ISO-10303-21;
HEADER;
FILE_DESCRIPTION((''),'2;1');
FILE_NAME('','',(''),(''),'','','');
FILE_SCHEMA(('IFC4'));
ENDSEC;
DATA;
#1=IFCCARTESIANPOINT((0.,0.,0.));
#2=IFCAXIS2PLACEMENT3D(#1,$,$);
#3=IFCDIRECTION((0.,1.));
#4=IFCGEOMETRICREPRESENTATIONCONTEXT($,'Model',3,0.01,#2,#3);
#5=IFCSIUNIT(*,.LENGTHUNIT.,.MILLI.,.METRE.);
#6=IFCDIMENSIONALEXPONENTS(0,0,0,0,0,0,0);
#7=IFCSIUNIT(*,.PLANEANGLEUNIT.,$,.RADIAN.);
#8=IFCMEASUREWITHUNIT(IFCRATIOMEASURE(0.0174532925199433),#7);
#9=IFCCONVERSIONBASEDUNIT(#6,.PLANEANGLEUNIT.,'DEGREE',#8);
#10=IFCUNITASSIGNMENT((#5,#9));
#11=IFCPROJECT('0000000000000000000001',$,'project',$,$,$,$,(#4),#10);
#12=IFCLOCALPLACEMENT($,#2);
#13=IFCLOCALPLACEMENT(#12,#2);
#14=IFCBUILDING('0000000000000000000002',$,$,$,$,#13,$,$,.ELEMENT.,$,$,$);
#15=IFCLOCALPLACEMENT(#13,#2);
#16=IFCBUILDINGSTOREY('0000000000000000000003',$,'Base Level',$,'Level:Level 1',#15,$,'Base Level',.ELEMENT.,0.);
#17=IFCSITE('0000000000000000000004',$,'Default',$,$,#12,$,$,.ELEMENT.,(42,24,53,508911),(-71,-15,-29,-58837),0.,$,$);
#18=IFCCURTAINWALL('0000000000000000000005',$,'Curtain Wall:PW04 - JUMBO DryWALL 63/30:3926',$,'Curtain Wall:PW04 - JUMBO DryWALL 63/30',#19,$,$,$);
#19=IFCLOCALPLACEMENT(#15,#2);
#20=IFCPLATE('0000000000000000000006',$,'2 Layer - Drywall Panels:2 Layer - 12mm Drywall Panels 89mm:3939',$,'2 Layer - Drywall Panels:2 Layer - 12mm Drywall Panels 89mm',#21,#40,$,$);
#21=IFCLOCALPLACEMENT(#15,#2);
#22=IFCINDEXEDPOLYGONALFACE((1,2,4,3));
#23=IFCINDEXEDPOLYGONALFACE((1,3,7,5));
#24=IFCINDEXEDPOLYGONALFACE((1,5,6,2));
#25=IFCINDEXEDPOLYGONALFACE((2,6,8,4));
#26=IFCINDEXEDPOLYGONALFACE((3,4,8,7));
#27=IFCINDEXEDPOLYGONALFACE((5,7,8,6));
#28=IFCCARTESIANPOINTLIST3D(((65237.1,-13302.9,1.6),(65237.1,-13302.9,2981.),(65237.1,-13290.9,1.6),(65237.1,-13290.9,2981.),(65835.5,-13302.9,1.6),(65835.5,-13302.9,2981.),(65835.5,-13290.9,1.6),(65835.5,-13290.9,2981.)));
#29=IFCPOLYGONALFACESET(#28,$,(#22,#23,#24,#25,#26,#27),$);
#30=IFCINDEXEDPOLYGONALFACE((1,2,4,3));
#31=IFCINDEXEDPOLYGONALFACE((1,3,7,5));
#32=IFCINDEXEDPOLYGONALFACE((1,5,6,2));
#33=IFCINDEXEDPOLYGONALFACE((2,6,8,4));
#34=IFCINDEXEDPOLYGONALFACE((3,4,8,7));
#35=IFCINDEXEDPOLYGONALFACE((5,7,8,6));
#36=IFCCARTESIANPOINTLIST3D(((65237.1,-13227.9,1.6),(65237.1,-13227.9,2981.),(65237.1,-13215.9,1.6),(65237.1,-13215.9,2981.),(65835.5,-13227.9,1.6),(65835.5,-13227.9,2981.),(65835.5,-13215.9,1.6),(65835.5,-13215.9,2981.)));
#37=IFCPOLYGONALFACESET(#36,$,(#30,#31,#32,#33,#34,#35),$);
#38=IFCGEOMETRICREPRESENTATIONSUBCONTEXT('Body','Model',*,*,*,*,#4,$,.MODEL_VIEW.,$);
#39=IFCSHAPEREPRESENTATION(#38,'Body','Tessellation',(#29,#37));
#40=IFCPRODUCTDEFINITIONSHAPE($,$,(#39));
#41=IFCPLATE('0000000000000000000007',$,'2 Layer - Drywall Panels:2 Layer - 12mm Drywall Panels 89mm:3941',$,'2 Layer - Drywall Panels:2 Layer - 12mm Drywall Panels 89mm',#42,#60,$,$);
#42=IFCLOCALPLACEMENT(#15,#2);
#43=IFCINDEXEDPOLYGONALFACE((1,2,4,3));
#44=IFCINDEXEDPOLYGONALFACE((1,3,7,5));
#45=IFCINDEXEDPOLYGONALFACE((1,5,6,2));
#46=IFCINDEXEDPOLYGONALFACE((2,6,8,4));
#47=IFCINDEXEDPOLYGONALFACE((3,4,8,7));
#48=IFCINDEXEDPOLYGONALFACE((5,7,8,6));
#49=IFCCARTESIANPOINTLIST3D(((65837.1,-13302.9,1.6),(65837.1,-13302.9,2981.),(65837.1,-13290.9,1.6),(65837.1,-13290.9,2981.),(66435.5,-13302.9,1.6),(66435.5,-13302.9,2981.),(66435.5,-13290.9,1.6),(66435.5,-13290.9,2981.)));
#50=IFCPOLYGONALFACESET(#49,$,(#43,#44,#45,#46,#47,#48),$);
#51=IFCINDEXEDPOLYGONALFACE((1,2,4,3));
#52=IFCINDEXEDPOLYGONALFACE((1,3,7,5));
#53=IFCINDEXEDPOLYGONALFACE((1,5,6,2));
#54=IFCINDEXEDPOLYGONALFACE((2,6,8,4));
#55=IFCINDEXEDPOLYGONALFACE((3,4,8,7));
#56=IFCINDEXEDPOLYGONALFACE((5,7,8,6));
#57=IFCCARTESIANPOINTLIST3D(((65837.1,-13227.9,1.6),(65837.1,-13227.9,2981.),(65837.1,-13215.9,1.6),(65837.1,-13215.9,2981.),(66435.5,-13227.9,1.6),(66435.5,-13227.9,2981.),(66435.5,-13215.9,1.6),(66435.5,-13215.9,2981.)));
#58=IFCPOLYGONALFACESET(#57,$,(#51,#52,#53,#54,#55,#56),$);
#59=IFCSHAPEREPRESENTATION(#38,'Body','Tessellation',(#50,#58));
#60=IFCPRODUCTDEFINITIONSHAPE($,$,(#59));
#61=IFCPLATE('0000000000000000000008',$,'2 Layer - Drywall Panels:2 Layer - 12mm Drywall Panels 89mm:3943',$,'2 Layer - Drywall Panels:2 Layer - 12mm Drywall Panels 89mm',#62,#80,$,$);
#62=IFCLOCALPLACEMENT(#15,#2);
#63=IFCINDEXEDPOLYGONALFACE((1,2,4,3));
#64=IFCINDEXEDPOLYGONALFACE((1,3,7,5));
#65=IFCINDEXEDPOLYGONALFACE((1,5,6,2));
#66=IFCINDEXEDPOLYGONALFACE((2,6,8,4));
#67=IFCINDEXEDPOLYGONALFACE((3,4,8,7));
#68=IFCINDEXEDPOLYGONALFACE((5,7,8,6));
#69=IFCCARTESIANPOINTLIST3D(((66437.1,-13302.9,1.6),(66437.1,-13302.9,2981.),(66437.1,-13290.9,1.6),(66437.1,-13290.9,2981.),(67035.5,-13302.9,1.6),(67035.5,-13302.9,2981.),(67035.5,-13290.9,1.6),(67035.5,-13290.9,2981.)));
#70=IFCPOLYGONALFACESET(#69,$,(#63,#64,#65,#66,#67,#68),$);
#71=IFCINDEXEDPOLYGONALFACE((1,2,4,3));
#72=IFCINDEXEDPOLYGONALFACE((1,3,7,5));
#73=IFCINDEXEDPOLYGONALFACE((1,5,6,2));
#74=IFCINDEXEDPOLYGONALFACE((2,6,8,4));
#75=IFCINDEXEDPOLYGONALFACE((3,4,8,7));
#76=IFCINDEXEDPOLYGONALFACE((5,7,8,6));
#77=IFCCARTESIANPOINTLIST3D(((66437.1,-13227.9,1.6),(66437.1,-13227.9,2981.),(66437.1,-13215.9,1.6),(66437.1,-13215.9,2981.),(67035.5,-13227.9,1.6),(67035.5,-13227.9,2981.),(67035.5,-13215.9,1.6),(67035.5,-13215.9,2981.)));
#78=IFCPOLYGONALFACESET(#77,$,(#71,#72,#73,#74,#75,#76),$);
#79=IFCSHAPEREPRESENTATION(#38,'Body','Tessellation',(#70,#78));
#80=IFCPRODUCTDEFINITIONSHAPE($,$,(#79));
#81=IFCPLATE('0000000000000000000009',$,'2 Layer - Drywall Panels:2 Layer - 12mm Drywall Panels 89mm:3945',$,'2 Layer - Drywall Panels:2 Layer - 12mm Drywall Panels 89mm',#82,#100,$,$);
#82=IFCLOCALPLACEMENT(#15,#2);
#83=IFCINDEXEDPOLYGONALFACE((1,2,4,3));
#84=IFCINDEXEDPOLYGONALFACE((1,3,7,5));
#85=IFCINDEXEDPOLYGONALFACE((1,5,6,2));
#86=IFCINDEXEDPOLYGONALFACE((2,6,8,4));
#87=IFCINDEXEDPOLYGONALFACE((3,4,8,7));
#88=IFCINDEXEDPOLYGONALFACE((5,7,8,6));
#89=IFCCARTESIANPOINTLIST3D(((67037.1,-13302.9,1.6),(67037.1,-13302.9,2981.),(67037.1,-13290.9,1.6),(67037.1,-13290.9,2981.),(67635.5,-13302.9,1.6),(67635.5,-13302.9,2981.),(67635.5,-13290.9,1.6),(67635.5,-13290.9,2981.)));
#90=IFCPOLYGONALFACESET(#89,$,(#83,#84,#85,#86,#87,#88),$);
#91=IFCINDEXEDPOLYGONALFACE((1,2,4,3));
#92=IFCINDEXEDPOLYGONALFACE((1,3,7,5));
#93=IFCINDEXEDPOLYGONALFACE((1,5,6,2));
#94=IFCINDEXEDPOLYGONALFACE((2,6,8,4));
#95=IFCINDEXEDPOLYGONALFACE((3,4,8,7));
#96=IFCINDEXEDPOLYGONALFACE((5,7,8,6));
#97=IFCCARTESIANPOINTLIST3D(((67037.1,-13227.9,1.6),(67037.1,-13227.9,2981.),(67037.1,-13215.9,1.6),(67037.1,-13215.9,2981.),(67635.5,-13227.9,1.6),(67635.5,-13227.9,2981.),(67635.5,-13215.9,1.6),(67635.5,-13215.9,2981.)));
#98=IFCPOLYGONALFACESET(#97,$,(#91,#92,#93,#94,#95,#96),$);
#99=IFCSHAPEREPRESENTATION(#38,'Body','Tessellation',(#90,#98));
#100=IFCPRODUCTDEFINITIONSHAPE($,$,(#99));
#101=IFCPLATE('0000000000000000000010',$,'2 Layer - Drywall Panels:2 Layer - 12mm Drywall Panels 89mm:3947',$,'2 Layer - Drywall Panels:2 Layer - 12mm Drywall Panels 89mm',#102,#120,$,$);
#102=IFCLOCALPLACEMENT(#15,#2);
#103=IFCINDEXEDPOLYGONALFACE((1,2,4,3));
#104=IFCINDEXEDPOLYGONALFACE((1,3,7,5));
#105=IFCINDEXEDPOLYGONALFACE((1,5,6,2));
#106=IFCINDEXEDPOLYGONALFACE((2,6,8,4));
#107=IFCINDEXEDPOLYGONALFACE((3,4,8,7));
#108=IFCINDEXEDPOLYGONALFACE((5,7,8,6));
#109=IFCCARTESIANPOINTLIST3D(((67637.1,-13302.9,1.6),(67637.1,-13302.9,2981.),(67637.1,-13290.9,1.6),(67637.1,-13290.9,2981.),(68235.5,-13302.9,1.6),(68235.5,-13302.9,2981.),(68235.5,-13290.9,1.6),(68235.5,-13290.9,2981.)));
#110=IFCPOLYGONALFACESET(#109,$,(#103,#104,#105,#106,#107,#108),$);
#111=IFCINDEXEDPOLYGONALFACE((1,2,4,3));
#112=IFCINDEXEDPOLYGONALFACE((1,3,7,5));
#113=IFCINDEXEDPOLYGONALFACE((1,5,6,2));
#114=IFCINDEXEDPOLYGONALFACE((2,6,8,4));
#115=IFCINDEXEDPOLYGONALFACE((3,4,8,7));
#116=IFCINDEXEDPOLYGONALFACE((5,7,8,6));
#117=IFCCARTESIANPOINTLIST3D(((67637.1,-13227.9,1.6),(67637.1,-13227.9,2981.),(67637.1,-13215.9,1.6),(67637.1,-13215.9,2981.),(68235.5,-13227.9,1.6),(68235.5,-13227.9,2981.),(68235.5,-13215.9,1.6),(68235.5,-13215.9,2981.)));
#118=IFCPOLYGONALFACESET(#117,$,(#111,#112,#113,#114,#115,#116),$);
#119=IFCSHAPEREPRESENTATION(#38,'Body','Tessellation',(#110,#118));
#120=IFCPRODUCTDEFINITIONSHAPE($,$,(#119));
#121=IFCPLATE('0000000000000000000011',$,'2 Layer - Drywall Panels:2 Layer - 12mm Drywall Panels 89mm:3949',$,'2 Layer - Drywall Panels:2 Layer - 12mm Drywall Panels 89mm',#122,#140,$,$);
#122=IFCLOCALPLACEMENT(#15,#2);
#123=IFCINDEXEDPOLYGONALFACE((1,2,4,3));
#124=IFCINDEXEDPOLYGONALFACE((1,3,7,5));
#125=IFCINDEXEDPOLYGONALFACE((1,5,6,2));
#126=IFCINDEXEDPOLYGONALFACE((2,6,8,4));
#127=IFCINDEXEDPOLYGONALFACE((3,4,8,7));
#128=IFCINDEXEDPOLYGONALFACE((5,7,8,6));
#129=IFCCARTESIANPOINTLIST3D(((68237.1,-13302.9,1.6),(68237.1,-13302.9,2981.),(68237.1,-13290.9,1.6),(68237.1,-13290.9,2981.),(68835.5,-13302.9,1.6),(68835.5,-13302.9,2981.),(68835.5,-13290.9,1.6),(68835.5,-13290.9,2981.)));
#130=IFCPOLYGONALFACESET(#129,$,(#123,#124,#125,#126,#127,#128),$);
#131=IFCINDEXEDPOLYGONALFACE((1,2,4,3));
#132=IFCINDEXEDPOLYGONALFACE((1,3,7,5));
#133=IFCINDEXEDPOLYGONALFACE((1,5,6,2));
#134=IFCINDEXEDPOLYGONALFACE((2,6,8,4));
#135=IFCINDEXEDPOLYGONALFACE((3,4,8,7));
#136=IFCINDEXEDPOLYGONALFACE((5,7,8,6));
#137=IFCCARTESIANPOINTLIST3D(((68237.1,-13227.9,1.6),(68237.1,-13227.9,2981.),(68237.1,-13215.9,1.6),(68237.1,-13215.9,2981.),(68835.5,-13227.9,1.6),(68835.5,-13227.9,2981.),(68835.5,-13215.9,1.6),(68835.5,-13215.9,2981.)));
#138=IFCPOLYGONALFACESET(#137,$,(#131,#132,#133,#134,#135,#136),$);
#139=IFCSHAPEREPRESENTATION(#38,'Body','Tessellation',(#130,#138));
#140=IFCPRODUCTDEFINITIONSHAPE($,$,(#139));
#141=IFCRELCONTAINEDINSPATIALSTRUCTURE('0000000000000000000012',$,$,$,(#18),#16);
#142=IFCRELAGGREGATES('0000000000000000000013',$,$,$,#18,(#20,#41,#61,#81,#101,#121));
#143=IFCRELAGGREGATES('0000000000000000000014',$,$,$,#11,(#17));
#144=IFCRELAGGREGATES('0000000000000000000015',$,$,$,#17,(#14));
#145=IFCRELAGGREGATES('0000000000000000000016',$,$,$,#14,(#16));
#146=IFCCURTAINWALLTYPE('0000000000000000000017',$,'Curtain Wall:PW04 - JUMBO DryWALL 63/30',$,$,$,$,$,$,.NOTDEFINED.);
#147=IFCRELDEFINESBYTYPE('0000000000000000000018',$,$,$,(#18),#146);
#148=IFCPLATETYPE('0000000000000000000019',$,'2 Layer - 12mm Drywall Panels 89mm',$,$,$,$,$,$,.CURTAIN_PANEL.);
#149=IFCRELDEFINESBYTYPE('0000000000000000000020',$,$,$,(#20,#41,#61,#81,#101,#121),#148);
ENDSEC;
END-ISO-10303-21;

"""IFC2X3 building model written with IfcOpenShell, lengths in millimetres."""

from ifc_helpers import new_model, entity, si_unit, converted_unit, direction, frame, frame_2d, origin, place, context, subcontext, project, spatial, rectangle, extrude, source, transform, mapped, type_object, type_shapes, element, aggregate, save


model = new_model("IFC2X3")

# Units and contexts
model_context = context("Model", 3, precision=0.01, world=origin(), true_north=direction((0.0, 1.0)))
body_context = subcontext(model_context, "Body", "Model", "MODEL_VIEW")
ifc_project = project(units=[si_unit("LENGTHUNIT", "METRE", prefix="MILLI"), converted_unit("PLANEANGLEUNIT", "DEGREE", entity("IfcRatioMeasure", 0.0174532925199433), si_unit("PLANEANGLEUNIT", "RADIAN"), dimensions=[0, 0, 0, 0, 0, 0, 0])], contexts=[model_context])

# Site, building, storey
site_placement = place(None, origin())
site = spatial("IfcSite", under=ifc_project, at=site_placement, Name="Default", CompositionType="ELEMENT", RefLatitude=(42, 24, 53, 508911), RefLongitude=(-71, -15, -29, -58837), RefElevation=0.0)
building_placement = place(site_placement, origin())
building = spatial("IfcBuilding", under=site, at=building_placement, CompositionType="ELEMENT")
storey_placement = place(building_placement, origin())
storey = spatial("IfcBuildingStorey", under=building, at=storey_placement, Name="Base Level", ObjectType="Level:Level 1", LongName="Base Level", CompositionType="ELEMENT", Elevation=0.0)

# Curtain wall, plates
curtain_wall_type = type_object("IfcCurtainWallType", Name="Curtain Wall:PW04 - JUMBO DryWALL 63/30", PredefinedType="NOTDEFINED")
curtain_wall_placement = place(building_placement, origin())
curtain_wall = element("IfcCurtainWall", 1, at=curtain_wall_placement, inside=storey, type_object=curtain_wall_type, Name="Curtain Wall:PW04 - JUMBO DryWALL 63/30:3926", ObjectType="Curtain Wall:PW04 - JUMBO DryWALL 63/30")
plate_type = type_object("IfcPlateType", Name="2 Layer - 12mm Drywall Panels 89mm", PredefinedType="CURTAIN_PANEL")
shared_shape_1 = source(origin(), body_context, "Body", "SweptSolid", [
    extrude(rectangle(XDim=598.4, YDim=12.0, at=frame_2d((0.0, 0.0), x_axis=(1.0, 0.0))), frame((0.0, -37.5, 0.0), z_axis=(0.0, 0.0, 1.0), x_axis=(-1.0, 0.0, 0.0)), (0.0, 0.0, 1.0), 2979.4),
    extrude(rectangle(XDim=12.0, YDim=598.4, at=frame_2d((0.0, 0.0), x_axis=(1.0, 0.0))), frame((0.0, 37.5, 0.0), z_axis=(0.0, 0.0, 1.0), x_axis=(0.0, 1.0, 0.0)), (0.0, 0.0, 1.0), 2979.4),
])
type_shapes(plate_type, [shared_shape_1])
plate_1_placement = place(curtain_wall_placement, frame((65536.3, -13259.4, 1.6)))
plate_1 = element("IfcPlate", 2, at=plate_1_placement, type_object=plate_type, Name="2 Layer - Drywall Panels:2 Layer - 12mm Drywall Panels 89mm:3939", ObjectType="2 Layer - Drywall Panels:2 Layer - 12mm Drywall Panels 89mm", context=body_context, shape_type="MappedRepresentation", body=[
    mapped(shared_shape_1, transform((0.0, 0.0, 0.0), scale=1.0)),
])
plate_2_placement = place(curtain_wall_placement, frame((66136.3, -13259.4, 1.6)))
plate_2 = element("IfcPlate", 3, at=plate_2_placement, type_object=plate_type, Name="2 Layer - Drywall Panels:2 Layer - 12mm Drywall Panels 89mm:3941", ObjectType="2 Layer - Drywall Panels:2 Layer - 12mm Drywall Panels 89mm", context=body_context, shape_type="MappedRepresentation", body=[
    mapped(shared_shape_1, transform((0.0, 0.0, 0.0), scale=1.0)),
])
plate_3_placement = place(curtain_wall_placement, frame((66736.3, -13259.4, 1.6)))
plate_3 = element("IfcPlate", 4, at=plate_3_placement, type_object=plate_type, Name="2 Layer - Drywall Panels:2 Layer - 12mm Drywall Panels 89mm:3943", ObjectType="2 Layer - Drywall Panels:2 Layer - 12mm Drywall Panels 89mm", context=body_context, shape_type="MappedRepresentation", body=[
    mapped(shared_shape_1, transform((0.0, 0.0, 0.0), scale=1.0)),
])
plate_4_placement = place(curtain_wall_placement, frame((67336.3, -13259.4, 1.6)))
plate_4 = element("IfcPlate", 5, at=plate_4_placement, type_object=plate_type, Name="2 Layer - Drywall Panels:2 Layer - 12mm Drywall Panels 89mm:3945", ObjectType="2 Layer - Drywall Panels:2 Layer - 12mm Drywall Panels 89mm", context=body_context, shape_type="MappedRepresentation", body=[
    mapped(shared_shape_1, transform((0.0, 0.0, 0.0), scale=1.0)),
])
plate_5_placement = place(curtain_wall_placement, frame((67936.3, -13259.4, 1.6)))
plate_5 = element("IfcPlate", 6, at=plate_5_placement, type_object=plate_type, Name="2 Layer - Drywall Panels:2 Layer - 12mm Drywall Panels 89mm:3947", ObjectType="2 Layer - Drywall Panels:2 Layer - 12mm Drywall Panels 89mm", context=body_context, shape_type="MappedRepresentation", body=[
    mapped(shared_shape_1, transform((0.0, 0.0, 0.0), scale=1.0)),
])
plate_6_placement = place(curtain_wall_placement, frame((68536.3, -13259.4, 1.6)))
plate_6 = element("IfcPlate", 7, at=plate_6_placement, type_object=plate_type, Name="2 Layer - Drywall Panels:2 Layer - 12mm Drywall Panels 89mm:3949", ObjectType="2 Layer - Drywall Panels:2 Layer - 12mm Drywall Panels 89mm", context=body_context, shape_type="MappedRepresentation", body=[
    mapped(shared_shape_1, transform((0.0, 0.0, 0.0), scale=1.0)),
])
aggregate(curtain_wall, [plate_1, plate_2, plate_3, plate_4, plate_5, plate_6])

save(model, "model.ifc")
